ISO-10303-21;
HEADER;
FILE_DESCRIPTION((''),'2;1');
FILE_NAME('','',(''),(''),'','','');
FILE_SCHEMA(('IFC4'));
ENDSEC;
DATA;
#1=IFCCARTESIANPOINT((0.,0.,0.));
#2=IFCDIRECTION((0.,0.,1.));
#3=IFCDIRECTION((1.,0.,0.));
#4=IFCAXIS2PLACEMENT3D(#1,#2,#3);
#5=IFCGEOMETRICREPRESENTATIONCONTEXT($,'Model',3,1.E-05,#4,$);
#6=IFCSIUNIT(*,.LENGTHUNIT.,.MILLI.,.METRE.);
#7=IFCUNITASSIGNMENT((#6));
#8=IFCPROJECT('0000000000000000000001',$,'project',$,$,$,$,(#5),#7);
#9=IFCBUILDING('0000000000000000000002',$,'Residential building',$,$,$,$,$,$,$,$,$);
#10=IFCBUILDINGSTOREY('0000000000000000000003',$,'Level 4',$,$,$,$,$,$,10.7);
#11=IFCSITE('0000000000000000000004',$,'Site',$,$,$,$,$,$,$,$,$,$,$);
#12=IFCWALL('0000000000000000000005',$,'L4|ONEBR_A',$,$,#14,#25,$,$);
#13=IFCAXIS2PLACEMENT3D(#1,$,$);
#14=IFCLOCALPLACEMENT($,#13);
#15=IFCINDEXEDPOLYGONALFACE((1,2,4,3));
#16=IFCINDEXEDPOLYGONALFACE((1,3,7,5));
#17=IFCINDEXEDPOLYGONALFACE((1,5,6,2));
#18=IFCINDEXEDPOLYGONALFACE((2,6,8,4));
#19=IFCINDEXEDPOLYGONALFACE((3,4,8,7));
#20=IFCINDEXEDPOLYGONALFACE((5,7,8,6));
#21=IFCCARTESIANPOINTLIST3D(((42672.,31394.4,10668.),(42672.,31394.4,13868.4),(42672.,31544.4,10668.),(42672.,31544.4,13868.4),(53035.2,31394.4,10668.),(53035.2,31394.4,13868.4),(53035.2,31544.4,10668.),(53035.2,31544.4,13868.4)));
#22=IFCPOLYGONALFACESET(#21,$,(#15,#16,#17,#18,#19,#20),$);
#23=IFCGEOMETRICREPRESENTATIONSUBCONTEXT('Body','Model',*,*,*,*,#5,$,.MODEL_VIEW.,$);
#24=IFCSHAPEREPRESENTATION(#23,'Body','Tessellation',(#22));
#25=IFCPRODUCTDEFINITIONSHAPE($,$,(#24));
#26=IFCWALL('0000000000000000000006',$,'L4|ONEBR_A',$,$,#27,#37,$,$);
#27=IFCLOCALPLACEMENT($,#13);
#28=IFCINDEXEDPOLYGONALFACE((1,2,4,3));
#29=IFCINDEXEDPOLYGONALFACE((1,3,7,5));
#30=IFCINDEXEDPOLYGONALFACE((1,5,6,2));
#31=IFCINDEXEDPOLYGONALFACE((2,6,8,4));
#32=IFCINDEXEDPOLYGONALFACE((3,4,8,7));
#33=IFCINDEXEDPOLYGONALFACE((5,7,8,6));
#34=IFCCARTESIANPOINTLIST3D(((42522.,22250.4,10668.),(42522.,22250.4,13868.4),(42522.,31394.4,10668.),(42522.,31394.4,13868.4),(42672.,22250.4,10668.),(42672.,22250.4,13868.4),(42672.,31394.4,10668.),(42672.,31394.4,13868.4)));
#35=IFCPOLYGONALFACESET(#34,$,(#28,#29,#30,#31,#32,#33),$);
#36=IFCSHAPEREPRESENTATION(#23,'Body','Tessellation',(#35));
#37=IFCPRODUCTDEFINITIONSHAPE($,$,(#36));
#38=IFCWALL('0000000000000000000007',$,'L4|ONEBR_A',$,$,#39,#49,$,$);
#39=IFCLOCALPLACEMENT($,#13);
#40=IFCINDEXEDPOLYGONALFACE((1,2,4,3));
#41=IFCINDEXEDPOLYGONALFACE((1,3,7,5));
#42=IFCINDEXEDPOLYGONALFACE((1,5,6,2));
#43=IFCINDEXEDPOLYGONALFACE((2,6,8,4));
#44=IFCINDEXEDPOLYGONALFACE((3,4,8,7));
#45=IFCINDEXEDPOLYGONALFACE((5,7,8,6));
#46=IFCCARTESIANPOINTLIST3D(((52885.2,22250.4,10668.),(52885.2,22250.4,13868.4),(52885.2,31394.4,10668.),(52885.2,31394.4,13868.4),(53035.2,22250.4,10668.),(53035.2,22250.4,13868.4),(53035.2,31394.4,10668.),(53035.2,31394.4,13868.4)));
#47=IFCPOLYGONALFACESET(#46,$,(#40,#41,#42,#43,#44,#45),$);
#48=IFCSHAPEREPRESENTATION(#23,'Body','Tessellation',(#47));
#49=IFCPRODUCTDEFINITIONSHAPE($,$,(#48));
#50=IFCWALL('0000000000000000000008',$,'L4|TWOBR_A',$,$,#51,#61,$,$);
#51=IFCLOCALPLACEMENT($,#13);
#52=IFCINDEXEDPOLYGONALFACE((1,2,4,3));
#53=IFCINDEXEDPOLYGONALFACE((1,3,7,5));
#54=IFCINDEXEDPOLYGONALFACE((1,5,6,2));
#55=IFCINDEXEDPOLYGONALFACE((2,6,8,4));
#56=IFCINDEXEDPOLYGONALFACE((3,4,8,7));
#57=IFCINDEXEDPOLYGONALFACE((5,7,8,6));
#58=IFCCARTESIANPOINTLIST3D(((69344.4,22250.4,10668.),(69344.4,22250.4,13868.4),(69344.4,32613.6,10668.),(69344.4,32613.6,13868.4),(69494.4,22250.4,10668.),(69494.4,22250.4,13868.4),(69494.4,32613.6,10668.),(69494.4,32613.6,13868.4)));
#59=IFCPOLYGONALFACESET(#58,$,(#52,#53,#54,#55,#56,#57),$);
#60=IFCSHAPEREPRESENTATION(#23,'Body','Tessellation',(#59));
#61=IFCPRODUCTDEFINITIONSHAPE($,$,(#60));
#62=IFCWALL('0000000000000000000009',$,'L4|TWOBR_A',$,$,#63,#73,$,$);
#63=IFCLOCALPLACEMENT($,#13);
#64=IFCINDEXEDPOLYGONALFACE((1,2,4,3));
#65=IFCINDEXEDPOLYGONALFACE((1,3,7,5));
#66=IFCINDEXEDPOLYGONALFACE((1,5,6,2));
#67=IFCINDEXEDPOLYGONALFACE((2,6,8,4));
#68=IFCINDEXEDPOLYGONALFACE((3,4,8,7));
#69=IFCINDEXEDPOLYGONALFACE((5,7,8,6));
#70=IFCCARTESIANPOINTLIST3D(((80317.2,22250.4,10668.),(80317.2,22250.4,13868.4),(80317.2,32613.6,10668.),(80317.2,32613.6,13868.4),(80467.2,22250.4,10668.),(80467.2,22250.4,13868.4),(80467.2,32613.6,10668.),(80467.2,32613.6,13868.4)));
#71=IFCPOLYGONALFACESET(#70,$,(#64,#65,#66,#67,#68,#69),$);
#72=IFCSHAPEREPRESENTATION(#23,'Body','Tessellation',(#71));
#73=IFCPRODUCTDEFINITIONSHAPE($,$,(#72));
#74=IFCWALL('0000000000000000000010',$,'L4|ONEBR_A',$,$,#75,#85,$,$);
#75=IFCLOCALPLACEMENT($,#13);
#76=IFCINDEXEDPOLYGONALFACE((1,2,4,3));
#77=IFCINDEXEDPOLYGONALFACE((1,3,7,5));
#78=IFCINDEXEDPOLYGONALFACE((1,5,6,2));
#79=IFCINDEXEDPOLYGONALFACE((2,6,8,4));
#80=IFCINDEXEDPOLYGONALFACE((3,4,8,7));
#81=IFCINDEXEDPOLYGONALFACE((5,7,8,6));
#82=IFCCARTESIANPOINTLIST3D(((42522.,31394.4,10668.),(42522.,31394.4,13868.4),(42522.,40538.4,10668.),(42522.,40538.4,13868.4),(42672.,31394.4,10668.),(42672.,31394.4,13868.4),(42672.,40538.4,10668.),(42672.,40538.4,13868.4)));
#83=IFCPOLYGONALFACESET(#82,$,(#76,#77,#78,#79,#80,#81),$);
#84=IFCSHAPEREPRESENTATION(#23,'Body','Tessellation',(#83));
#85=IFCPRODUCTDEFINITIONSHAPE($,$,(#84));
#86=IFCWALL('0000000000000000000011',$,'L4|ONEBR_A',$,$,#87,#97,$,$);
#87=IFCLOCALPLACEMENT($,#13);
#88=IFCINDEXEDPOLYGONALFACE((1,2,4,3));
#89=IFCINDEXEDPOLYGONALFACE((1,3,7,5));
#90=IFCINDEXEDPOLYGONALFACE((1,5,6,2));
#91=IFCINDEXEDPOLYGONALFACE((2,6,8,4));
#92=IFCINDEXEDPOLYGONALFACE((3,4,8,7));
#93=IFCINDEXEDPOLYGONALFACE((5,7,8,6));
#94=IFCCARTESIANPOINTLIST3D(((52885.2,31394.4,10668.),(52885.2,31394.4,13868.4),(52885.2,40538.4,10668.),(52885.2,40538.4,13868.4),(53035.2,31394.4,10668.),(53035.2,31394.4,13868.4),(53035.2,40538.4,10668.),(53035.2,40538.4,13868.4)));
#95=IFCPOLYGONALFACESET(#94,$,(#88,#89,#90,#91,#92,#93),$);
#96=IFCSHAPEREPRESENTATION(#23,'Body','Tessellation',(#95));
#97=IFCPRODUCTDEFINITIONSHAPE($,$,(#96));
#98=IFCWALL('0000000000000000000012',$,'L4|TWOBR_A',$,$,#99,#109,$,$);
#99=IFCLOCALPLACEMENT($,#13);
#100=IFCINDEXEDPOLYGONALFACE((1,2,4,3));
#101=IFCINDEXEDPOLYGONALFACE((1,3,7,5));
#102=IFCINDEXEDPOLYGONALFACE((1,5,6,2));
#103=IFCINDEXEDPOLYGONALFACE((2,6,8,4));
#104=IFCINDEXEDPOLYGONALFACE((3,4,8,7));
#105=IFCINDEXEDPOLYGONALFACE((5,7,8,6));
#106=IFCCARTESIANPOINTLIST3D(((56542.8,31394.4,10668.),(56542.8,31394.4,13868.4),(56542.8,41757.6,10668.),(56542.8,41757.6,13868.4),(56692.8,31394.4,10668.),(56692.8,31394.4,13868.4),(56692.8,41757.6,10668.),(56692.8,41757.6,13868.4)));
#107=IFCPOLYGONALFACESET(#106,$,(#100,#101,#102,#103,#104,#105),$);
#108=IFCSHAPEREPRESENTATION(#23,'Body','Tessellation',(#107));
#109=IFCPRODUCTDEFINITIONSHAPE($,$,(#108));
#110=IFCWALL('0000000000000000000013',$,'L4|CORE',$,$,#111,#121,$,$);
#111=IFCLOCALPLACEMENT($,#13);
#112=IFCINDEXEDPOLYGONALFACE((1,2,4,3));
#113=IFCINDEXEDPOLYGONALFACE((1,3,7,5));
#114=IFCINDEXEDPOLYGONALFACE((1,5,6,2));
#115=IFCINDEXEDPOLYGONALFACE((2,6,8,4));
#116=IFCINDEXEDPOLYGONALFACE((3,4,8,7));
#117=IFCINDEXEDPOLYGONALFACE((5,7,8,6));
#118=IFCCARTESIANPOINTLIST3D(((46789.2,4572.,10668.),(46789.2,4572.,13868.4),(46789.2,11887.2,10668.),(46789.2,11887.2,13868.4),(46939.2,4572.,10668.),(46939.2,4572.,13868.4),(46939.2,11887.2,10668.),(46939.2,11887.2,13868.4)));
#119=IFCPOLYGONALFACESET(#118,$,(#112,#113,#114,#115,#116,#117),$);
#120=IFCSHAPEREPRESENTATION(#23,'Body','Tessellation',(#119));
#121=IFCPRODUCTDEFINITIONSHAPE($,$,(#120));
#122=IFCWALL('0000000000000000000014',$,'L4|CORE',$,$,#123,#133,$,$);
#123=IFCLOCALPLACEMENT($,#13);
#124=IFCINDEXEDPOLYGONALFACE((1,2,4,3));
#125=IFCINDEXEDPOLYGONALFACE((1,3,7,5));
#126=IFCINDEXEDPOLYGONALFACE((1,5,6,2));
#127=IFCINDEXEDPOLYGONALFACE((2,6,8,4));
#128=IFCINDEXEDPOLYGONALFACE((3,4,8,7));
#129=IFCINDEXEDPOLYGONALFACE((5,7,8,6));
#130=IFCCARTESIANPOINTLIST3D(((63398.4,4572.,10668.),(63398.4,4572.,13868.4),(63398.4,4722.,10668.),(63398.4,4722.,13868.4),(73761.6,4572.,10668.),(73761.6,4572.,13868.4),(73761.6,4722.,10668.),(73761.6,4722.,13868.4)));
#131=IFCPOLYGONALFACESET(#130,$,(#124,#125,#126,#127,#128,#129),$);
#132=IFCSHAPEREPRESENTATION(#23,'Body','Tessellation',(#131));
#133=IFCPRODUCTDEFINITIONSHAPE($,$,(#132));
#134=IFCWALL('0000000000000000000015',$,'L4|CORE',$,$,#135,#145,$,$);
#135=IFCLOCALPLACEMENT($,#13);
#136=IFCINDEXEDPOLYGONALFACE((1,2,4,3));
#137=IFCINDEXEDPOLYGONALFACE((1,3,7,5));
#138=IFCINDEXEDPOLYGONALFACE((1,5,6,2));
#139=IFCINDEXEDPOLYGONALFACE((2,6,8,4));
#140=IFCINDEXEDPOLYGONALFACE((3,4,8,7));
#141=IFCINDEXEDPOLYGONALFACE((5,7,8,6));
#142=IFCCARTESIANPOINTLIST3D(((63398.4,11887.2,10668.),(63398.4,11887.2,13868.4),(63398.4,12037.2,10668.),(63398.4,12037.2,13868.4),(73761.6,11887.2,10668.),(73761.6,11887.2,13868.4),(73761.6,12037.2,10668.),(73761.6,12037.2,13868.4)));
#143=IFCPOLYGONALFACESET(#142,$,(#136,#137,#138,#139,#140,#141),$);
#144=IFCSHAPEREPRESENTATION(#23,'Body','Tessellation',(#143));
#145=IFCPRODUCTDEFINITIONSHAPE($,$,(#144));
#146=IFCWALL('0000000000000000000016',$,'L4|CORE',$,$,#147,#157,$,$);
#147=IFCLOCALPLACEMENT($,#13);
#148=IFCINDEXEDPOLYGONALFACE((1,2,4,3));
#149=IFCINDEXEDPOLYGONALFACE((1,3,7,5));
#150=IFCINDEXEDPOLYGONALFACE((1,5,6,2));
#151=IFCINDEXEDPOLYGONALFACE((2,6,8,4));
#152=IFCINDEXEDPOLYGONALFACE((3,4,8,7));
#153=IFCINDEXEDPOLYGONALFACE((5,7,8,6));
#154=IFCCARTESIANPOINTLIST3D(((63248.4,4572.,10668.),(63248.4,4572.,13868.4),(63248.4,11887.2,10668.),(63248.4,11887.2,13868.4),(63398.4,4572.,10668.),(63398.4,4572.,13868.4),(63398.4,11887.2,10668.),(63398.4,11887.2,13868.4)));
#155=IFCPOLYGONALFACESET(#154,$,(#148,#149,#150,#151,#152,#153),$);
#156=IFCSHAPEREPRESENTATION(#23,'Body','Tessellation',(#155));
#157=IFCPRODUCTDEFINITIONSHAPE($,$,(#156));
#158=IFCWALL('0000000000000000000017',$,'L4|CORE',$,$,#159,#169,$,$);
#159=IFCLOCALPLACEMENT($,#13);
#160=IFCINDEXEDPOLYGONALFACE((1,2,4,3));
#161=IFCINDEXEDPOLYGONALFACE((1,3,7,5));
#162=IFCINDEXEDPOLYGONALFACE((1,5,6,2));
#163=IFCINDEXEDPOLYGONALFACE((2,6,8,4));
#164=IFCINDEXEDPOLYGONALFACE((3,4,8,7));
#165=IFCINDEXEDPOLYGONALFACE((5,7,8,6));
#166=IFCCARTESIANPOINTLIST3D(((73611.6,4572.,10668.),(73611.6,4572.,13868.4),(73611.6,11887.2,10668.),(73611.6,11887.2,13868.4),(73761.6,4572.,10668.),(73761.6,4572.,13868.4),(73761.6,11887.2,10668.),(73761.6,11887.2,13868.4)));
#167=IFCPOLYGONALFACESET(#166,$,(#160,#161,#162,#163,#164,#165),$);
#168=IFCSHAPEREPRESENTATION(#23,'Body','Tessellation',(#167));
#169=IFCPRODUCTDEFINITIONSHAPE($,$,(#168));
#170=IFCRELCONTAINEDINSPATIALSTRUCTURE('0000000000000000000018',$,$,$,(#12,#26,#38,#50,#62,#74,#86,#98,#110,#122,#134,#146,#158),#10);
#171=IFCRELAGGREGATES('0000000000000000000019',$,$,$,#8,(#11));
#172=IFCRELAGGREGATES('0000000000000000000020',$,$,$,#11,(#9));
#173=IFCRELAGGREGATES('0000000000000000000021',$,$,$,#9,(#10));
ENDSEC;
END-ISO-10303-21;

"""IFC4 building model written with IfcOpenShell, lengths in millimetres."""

from ifc_helpers import new_model, si_unit, frame, origin_with_axes, place, context, subcontext, project, spatial, indexed_curve, outline, extrude, element, save


model = new_model("IFC4")

# Units and contexts
model_context = context("Model", 3, precision=1e-05, world=origin_with_axes())
body_context = subcontext(model_context, "Body", "Model", "MODEL_VIEW")
ifc_project = project(units=[si_unit("LENGTHUNIT", "METRE", prefix="MILLI")], contexts=[model_context])

# Site, building, storey
site = spatial("IfcSite", under=ifc_project, Name="Site")
building = spatial("IfcBuilding", under=site, Name="Residential building")
storey = spatial("IfcBuildingStorey", under=building, Name="Level 4", Elevation=10.7)

# Walls
for number, where, z_axis, x_axis, name in (
    (1, (42672.0, 31394.4, 10668.0), (0.0, 0.0, 1.0), (1.0, 0.0, 0.0), "L4|ONEBR_A"),
):
    element("IfcWall", number, at=place(None, frame(where, z_axis=z_axis, x_axis=x_axis)), inside=storey, Name=name, context=body_context, shape_type="SweptSolid", body=[
        extrude(outline(indexed_curve([(0.0, 0.0), (0.0, 150.0), (10363.2, 150.0), (10363.2, 0.0), (0.0, 0.0)], self_intersect=False)), origin_with_axes(), (0.0, 0.0, 1.0), 3200.4),
    ])
for number, where, z_axis, x_axis, name in (
    (2, (42672.0, 22250.4, 10668.0), (0.0, 0.0, 1.0), (0.0, 1.0, 0.0), "L4|ONEBR_A"),
    (3, (53035.2, 22250.4, 10668.0), (0.0, 0.0, 1.0), (0.0, 1.0, 0.0), "L4|ONEBR_A"),
):
    element("IfcWall", number, at=place(None, frame(where, z_axis=z_axis, x_axis=x_axis)), inside=storey, Name=name, context=body_context, shape_type="SweptSolid", body=[
        extrude(outline(indexed_curve([(0.0, 0.0), (0.0, 150.0), (9144.0, 150.0), (9144.0, 0.0), (0.0, 0.0)], self_intersect=False)), origin_with_axes(), (0.0, 0.0, 1.0), 3200.4),
    ])
for number, where, z_axis, x_axis, name in (
    (4, (69494.4, 22250.4, 10668.0), (0.0, 0.0, 1.0), (0.0, 1.0, 0.0), "L4|TWOBR_A"),
    (5, (80467.2, 22250.4, 10668.0), (0.0, 0.0, 1.0), (0.0, 1.0, 0.0), "L4|TWOBR_A"),
):
    element("IfcWall", number, at=place(None, frame(where, z_axis=z_axis, x_axis=x_axis)), inside=storey, Name=name, context=body_context, shape_type="SweptSolid", body=[
        extrude(outline(indexed_curve([(0.0, 0.0), (0.0, 150.0), (10363.2, 150.0), (10363.2, 0.0), (0.0, 0.0)], self_intersect=False)), origin_with_axes(), (0.0, 0.0, 1.0), 3200.4),
    ])
for number, where, z_axis, x_axis, name in (
    (6, (42672.0, 31394.4, 10668.0), (0.0, 0.0, 1.0), (0.0, 1.0, 0.0), "L4|ONEBR_A"),
    (7, (53035.2, 31394.4, 10668.0), (0.0, 0.0, 1.0), (0.0, 1.0, 0.0), "L4|ONEBR_A"),
):
    element("IfcWall", number, at=place(None, frame(where, z_axis=z_axis, x_axis=x_axis)), inside=storey, Name=name, context=body_context, shape_type="SweptSolid", body=[
        extrude(outline(indexed_curve([(0.0, 0.0), (0.0, 150.0), (9144.0, 150.0), (9144.0, 0.0), (0.0, 0.0)], self_intersect=False)), origin_with_axes(), (0.0, 0.0, 1.0), 3200.4),
    ])
wall_1_placement = place(None, frame((56692.8, 31394.4, 10668.0), z_axis=(0.0, 0.0, 1.0), x_axis=(0.0, 1.0, 0.0)))
element("IfcWall", 8, at=wall_1_placement, inside=storey, Name="L4|TWOBR_A", context=body_context, shape_type="SweptSolid", body=[
    extrude(outline(indexed_curve([(0.0, 0.0), (0.0, 150.0), (10363.2, 150.0), (10363.2, 0.0), (0.0, 0.0)], self_intersect=False)), origin_with_axes(), (0.0, 0.0, 1.0), 3200.4),
])
wall_2_placement = place(None, frame((46939.2, 4572.0, 10668.0), z_axis=(0.0, 0.0, 1.0), x_axis=(0.0, 1.0, 0.0)))
element("IfcWall", 9, at=wall_2_placement, inside=storey, Name="L4|CORE", context=body_context, shape_type="SweptSolid", body=[
    extrude(outline(indexed_curve([(0.0, 0.0), (0.0, 150.0), (7315.2, 150.0), (7315.2, 0.0), (0.0, 0.0)], self_intersect=False)), origin_with_axes(), (0.0, 0.0, 1.0), 3200.4),
])
for number, where, z_axis, x_axis, name in (
    (10, (63398.4, 4572.0, 10668.0), (0.0, 0.0, 1.0), (1.0, 0.0, 0.0), "L4|CORE"),
    (11, (63398.4, 11887.2, 10668.0), (0.0, 0.0, 1.0), (1.0, 0.0, 0.0), "L4|CORE"),
):
    element("IfcWall", number, at=place(None, frame(where, z_axis=z_axis, x_axis=x_axis)), inside=storey, Name=name, context=body_context, shape_type="SweptSolid", body=[
        extrude(outline(indexed_curve([(0.0, 0.0), (0.0, 150.0), (10363.2, 150.0), (10363.2, 0.0), (0.0, 0.0)], self_intersect=False)), origin_with_axes(), (0.0, 0.0, 1.0), 3200.4),
    ])
for number, where, z_axis, x_axis, name in (
    (12, (63398.4, 4572.0, 10668.0), (0.0, 0.0, 1.0), (0.0, 1.0, 0.0), "L4|CORE"),
    (13, (73761.6, 4572.0, 10668.0), (0.0, 0.0, 1.0), (0.0, 1.0, 0.0), "L4|CORE"),
):
    element("IfcWall", number, at=place(None, frame(where, z_axis=z_axis, x_axis=x_axis)), inside=storey, Name=name, context=body_context, shape_type="SweptSolid", body=[
        extrude(outline(indexed_curve([(0.0, 0.0), (0.0, 150.0), (7315.2, 150.0), (7315.2, 0.0), (0.0, 0.0)], self_intersect=False)), origin_with_axes(), (0.0, 0.0, 1.0), 3200.4),
    ])

save(model, "model.ifc")
